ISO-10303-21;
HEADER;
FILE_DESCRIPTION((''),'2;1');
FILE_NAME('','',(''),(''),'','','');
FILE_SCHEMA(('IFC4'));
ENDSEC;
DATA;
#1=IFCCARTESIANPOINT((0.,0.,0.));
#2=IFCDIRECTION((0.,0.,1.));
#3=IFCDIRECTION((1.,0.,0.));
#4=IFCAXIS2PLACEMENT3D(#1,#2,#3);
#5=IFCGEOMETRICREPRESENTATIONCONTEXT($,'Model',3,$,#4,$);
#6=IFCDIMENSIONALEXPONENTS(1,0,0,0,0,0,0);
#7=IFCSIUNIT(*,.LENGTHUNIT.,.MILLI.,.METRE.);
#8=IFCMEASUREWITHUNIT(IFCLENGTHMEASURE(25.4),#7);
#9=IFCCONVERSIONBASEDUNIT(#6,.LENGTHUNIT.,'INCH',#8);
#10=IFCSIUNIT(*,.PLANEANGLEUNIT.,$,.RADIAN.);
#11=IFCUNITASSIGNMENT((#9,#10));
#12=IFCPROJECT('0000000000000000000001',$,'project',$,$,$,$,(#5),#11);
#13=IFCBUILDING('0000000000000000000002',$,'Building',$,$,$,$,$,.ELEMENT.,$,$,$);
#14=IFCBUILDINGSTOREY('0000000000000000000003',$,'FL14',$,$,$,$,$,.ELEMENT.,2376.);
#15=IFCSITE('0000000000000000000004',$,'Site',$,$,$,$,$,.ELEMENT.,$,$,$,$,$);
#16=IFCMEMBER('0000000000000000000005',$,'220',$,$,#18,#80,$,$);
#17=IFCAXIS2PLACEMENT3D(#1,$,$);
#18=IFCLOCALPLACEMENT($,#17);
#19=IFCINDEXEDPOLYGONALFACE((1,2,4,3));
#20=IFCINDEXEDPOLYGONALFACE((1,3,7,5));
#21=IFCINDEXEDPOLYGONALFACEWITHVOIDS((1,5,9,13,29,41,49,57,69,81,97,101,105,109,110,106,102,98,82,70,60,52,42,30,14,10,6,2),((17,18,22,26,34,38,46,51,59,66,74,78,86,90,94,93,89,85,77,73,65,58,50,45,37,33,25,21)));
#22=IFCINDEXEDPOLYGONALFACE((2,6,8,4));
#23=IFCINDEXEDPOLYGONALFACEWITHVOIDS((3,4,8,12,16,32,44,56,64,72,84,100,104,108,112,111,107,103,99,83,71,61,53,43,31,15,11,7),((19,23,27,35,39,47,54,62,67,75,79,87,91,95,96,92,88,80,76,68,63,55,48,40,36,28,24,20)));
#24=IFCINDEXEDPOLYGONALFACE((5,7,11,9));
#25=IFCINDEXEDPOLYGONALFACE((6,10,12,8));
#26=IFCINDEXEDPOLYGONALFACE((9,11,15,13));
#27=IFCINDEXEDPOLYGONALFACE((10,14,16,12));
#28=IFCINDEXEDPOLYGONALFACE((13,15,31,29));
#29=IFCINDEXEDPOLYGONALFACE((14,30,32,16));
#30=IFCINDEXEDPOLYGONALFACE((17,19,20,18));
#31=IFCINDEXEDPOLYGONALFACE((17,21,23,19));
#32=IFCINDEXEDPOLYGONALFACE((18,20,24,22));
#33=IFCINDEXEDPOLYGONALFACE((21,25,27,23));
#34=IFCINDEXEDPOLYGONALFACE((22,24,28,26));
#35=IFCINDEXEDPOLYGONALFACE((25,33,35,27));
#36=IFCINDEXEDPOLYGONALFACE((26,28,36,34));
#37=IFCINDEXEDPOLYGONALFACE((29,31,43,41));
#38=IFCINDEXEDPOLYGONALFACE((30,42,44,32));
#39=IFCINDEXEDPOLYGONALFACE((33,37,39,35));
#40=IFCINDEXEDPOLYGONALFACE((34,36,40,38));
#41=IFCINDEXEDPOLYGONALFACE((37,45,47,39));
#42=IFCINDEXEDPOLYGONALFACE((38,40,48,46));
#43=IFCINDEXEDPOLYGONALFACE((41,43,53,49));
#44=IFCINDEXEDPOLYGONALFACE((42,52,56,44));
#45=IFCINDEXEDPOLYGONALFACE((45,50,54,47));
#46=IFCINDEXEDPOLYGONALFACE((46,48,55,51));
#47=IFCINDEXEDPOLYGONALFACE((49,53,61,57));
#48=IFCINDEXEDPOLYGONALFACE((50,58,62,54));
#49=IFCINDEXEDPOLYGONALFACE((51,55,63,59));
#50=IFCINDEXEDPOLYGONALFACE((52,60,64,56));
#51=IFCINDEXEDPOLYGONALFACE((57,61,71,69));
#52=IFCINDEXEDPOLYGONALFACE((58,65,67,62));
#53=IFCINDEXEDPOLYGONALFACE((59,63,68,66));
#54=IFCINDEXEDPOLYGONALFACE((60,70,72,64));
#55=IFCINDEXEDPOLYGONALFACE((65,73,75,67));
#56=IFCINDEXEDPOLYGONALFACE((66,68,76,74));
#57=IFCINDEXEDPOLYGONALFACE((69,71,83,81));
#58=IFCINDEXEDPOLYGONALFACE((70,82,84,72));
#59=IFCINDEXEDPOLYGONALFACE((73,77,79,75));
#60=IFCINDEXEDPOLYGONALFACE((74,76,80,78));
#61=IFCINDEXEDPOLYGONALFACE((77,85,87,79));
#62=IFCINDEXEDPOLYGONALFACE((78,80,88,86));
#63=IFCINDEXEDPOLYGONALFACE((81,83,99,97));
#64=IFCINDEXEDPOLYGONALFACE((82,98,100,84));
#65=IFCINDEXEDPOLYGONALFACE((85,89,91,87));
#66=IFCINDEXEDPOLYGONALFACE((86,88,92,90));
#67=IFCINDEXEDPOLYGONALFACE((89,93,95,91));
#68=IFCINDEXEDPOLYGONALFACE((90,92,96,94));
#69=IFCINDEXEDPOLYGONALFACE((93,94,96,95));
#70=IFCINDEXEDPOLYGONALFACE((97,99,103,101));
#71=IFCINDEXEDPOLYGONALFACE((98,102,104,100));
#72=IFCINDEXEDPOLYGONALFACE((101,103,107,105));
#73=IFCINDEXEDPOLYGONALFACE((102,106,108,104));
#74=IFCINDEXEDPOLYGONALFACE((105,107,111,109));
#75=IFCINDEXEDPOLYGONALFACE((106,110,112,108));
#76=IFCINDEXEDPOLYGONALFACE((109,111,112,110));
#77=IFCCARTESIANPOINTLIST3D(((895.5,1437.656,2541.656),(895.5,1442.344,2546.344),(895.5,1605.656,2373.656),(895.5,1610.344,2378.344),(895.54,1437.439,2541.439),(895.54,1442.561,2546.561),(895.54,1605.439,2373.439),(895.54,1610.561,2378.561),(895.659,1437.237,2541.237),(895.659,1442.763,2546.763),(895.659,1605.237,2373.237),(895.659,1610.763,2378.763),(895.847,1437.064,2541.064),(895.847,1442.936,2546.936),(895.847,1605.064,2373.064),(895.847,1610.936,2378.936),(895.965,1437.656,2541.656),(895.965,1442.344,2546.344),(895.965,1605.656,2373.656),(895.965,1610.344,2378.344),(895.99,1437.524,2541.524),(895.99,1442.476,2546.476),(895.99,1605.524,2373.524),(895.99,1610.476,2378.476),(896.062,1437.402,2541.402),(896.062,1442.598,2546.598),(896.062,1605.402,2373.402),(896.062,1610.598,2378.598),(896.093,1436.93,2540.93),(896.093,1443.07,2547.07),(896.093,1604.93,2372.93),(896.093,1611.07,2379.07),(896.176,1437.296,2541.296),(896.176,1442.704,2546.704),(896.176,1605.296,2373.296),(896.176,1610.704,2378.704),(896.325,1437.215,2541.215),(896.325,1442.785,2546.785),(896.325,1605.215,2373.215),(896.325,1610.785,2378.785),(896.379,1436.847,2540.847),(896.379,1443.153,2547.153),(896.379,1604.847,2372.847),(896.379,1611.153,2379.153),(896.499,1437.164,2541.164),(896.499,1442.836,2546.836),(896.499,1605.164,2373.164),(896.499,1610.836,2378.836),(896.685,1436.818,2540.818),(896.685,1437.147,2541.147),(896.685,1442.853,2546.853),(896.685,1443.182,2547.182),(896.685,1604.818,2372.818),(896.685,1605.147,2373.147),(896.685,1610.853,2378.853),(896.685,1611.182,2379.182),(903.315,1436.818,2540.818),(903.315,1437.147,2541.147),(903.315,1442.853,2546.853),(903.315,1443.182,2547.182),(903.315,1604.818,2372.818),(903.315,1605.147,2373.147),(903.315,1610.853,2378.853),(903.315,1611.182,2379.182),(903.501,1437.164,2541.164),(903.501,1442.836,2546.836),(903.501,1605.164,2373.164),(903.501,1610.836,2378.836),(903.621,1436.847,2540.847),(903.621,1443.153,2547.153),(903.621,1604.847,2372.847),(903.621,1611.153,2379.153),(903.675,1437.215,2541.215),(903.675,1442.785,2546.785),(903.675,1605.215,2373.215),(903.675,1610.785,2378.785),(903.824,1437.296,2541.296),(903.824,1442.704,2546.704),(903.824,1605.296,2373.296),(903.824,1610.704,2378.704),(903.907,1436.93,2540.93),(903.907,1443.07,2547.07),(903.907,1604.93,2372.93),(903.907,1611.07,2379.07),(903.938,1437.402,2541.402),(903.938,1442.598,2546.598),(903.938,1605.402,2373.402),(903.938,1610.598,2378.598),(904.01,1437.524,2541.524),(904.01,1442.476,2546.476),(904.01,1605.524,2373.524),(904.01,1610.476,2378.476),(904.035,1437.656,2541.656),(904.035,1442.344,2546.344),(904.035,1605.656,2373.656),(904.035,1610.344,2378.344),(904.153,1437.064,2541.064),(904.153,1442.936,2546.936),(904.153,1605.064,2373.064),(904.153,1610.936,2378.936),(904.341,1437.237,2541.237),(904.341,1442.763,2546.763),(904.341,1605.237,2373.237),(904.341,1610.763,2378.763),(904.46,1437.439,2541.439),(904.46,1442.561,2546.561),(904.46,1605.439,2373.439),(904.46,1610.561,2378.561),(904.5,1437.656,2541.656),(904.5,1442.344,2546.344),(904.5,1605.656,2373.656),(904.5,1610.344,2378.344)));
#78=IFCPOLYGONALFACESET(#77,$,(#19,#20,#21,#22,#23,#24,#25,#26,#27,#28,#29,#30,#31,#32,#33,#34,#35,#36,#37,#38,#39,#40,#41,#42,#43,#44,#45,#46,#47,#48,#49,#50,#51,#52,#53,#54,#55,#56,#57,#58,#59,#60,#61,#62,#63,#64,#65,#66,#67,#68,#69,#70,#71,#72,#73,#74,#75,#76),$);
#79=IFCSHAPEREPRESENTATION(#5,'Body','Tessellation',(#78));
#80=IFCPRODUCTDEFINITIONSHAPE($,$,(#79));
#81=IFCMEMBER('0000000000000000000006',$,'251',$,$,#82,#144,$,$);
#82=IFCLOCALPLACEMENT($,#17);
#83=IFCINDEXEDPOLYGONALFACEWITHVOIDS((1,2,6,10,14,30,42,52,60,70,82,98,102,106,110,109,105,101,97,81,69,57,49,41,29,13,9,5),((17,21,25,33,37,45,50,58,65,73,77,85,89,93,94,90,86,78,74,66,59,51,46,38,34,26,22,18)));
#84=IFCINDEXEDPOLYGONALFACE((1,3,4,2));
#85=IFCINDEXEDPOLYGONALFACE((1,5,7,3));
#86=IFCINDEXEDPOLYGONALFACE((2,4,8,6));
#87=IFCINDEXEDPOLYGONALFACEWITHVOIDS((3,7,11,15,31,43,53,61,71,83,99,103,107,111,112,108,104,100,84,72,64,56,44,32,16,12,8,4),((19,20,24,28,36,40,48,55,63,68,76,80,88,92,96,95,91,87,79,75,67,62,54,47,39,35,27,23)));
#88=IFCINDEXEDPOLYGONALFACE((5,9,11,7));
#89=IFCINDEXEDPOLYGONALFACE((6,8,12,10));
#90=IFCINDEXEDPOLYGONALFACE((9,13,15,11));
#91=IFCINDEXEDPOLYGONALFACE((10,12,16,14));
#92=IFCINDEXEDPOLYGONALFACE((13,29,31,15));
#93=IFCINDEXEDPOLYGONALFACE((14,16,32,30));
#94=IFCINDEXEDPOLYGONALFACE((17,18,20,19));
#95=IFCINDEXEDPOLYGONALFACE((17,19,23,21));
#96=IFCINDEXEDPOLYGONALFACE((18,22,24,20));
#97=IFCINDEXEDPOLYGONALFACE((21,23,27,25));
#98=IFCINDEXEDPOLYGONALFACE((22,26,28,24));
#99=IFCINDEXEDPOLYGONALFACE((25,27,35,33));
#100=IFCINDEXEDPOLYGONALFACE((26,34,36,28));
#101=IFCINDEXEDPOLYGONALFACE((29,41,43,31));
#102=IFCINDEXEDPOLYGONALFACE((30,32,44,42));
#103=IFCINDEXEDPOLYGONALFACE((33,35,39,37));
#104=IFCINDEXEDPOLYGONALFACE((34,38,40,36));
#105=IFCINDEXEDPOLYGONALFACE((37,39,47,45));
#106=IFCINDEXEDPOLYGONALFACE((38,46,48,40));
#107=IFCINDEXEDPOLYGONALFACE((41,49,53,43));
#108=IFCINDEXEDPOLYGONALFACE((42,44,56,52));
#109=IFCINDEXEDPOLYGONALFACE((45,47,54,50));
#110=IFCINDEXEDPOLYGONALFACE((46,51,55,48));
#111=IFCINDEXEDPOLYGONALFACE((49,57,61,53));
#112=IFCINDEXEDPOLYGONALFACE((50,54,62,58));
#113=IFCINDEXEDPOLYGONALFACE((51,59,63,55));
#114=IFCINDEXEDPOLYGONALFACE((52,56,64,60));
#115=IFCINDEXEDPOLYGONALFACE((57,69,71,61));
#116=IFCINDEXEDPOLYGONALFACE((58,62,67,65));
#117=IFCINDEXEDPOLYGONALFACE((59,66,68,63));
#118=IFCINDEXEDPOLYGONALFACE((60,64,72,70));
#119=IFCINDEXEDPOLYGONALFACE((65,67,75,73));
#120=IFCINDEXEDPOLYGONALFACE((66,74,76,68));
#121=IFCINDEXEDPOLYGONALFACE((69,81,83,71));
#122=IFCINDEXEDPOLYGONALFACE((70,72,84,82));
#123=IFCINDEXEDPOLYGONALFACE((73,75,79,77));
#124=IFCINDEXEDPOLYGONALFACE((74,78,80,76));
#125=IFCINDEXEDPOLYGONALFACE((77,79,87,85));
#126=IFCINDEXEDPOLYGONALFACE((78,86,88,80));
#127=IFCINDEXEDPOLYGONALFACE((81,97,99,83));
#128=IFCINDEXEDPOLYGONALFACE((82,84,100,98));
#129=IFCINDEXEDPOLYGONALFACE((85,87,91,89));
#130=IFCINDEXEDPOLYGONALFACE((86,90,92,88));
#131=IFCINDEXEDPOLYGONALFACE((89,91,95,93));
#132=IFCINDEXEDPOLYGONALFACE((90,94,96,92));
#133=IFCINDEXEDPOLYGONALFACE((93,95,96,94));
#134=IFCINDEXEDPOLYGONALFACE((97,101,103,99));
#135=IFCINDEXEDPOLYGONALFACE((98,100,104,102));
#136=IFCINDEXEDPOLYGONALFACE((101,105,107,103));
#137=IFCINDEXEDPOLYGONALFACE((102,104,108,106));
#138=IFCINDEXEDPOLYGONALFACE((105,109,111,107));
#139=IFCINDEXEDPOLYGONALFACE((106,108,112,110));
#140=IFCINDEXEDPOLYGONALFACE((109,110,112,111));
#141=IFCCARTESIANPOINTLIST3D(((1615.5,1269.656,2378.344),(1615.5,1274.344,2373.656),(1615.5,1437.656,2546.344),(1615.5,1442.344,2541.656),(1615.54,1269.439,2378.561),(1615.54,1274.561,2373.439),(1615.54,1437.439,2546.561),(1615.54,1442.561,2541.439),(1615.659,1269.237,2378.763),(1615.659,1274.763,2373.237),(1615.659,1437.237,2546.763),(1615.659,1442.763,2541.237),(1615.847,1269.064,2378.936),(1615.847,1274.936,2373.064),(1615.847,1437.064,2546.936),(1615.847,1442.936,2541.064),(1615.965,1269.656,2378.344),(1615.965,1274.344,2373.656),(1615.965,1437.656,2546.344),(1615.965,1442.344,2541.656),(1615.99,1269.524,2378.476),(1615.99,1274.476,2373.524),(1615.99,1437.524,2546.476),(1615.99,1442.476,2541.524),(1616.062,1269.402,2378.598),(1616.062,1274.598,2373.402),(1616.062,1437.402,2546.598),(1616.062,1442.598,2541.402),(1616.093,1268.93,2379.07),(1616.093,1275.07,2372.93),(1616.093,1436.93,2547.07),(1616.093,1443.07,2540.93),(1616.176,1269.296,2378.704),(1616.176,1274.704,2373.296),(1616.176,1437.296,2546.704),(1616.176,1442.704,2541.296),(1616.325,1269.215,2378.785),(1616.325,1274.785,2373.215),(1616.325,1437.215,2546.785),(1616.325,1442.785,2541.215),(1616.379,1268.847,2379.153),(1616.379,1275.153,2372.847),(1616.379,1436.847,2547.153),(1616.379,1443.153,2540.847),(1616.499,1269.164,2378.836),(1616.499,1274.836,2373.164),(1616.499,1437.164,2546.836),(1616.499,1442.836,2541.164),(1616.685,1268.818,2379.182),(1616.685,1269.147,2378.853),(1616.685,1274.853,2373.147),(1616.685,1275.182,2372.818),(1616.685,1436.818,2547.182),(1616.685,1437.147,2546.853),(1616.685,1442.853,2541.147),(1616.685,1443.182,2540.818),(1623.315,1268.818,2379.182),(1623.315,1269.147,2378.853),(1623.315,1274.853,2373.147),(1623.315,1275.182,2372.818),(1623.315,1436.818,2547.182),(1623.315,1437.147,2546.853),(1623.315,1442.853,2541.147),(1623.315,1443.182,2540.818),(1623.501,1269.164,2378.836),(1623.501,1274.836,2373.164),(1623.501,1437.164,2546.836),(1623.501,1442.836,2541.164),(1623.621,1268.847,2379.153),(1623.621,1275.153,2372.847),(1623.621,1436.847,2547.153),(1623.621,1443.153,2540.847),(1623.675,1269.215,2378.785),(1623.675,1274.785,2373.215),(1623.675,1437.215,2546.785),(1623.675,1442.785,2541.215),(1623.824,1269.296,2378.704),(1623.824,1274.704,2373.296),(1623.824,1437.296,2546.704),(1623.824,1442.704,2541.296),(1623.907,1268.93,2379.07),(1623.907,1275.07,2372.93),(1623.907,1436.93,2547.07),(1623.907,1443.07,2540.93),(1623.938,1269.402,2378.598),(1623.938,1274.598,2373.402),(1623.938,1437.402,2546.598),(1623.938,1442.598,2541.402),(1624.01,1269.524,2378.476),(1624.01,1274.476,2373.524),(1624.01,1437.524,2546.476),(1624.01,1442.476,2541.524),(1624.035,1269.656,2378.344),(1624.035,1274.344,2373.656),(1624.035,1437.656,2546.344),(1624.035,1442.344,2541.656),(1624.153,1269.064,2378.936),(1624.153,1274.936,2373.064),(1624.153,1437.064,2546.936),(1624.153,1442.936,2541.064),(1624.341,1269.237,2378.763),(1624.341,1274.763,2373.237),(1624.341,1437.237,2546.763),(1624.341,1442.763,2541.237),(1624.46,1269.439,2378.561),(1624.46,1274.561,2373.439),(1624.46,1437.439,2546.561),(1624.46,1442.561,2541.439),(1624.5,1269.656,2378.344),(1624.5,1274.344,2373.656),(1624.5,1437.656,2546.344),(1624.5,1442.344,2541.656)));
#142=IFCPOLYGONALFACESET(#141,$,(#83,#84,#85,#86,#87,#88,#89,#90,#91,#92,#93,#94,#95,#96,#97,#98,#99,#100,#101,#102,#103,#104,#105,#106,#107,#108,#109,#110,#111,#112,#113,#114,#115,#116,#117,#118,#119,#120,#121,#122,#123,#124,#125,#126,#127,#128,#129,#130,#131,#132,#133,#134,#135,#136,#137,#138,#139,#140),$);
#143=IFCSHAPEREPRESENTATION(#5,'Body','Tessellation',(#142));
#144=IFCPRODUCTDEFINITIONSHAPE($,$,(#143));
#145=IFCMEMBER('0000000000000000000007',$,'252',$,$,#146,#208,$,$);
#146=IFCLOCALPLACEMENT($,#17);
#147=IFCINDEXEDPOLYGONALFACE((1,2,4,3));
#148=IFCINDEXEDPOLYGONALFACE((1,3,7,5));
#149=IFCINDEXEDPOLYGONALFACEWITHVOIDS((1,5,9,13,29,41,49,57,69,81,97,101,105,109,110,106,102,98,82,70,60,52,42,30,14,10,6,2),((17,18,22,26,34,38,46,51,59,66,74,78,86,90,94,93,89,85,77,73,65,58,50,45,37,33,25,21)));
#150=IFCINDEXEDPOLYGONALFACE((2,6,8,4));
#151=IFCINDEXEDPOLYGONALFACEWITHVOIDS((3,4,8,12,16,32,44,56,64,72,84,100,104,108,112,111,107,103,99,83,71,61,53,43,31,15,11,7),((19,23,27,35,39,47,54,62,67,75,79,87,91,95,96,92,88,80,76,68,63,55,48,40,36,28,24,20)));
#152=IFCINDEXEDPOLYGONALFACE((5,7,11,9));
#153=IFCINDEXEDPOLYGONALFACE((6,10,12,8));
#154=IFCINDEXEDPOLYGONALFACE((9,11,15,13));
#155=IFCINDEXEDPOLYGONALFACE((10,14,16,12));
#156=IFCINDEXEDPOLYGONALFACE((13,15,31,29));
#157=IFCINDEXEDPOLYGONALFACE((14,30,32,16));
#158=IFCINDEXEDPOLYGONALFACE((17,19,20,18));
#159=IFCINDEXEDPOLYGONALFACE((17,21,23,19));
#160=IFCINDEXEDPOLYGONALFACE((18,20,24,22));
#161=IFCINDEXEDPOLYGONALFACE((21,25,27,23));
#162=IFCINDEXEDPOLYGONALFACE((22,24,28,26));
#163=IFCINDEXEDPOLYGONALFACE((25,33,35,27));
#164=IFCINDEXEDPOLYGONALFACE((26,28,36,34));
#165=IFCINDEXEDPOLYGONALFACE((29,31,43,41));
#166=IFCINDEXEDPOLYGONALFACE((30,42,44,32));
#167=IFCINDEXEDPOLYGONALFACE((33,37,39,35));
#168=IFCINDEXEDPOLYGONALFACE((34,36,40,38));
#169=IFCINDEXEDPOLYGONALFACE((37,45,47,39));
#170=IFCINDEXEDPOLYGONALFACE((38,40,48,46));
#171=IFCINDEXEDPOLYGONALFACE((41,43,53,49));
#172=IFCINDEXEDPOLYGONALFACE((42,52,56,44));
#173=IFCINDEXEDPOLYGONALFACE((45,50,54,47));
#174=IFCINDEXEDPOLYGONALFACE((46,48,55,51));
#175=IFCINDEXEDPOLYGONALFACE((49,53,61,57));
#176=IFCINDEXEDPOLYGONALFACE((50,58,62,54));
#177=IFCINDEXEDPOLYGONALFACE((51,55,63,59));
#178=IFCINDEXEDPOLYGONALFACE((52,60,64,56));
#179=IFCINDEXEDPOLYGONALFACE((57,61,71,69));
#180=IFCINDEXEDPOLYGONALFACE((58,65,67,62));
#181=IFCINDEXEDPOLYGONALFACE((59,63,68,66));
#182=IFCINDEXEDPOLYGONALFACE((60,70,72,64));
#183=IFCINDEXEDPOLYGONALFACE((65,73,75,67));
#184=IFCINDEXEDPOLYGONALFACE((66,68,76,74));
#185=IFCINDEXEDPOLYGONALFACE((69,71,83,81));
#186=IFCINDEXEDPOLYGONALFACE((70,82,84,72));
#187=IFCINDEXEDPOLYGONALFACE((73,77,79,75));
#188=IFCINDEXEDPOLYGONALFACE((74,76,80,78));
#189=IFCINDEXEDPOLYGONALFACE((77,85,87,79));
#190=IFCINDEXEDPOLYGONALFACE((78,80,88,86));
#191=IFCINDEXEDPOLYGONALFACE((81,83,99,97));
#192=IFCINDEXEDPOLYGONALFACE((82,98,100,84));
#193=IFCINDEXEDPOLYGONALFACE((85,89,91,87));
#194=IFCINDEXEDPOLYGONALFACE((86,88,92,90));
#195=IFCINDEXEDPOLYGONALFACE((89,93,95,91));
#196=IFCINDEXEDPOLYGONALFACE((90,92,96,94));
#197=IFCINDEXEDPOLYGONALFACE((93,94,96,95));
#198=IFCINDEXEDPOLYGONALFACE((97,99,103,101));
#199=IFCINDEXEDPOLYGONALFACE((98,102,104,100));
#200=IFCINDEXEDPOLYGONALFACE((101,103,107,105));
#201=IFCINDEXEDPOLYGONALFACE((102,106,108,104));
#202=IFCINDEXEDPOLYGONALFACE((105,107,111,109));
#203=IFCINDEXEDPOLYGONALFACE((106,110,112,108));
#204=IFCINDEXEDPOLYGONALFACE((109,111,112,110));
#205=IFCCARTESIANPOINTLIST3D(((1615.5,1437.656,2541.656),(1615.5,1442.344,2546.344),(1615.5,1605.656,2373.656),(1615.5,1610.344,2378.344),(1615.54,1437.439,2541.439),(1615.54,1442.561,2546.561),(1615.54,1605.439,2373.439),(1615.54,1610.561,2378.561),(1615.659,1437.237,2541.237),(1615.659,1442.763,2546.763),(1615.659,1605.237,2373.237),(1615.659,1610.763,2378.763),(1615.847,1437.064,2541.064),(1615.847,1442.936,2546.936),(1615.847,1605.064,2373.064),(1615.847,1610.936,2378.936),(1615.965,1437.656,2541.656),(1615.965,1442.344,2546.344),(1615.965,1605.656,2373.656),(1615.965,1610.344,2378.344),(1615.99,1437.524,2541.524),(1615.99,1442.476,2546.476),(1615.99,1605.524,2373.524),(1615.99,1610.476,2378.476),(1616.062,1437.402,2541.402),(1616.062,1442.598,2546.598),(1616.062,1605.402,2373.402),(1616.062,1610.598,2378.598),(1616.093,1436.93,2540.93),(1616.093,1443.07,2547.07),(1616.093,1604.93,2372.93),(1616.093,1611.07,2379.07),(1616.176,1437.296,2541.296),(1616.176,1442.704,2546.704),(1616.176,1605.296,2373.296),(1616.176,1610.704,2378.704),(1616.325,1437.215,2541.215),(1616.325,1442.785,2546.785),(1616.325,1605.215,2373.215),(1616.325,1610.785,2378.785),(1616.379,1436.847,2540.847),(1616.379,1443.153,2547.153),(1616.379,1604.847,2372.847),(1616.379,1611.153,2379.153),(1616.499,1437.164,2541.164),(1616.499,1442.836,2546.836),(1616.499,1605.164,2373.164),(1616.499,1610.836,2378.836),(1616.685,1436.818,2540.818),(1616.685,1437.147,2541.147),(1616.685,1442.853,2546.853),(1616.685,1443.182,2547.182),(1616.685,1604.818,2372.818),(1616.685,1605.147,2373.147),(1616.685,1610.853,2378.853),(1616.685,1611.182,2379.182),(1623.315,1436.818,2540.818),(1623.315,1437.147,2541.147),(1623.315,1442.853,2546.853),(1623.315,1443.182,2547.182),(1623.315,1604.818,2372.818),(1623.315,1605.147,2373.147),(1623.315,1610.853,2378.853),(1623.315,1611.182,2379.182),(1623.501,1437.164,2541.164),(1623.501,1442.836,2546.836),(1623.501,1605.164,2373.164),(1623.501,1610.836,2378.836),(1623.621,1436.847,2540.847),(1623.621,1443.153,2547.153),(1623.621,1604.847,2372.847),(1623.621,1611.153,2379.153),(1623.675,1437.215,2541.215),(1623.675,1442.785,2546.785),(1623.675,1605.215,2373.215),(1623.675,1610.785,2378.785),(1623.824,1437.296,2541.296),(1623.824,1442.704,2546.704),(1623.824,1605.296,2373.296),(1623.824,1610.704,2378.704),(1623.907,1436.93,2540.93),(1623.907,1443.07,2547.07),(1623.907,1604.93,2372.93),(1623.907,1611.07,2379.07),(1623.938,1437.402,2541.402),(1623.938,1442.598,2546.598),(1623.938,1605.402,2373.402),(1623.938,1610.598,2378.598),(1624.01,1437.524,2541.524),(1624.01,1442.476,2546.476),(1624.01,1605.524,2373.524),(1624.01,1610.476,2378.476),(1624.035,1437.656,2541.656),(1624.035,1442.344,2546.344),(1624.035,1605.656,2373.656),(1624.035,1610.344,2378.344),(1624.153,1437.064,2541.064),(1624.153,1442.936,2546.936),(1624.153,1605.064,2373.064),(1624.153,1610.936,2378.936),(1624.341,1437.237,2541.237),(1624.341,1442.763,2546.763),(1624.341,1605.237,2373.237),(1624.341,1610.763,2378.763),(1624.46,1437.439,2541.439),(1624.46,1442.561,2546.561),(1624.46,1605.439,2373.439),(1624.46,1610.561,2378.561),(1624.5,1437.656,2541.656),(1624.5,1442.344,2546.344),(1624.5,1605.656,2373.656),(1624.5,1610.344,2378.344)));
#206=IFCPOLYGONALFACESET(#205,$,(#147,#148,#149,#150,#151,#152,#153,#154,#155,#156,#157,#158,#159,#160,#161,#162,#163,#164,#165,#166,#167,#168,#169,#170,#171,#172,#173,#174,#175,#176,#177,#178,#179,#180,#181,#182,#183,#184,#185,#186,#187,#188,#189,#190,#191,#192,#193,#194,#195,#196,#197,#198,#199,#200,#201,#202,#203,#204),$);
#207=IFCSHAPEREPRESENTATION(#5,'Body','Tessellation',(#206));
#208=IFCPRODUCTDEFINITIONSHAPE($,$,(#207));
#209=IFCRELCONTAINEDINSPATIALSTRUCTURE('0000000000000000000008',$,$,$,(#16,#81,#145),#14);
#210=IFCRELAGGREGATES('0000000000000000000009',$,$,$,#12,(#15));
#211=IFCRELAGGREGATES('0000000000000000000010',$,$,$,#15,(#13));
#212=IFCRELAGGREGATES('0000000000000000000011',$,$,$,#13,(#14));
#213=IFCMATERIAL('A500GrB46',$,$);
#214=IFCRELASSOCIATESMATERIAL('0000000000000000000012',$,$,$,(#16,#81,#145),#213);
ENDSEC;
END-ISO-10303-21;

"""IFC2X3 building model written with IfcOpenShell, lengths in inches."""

from ifc_helpers import new_model, entity, si_unit, converted_unit, frame, origin_with_axes, origin_2d_with_axis, place, context, project, spatial, hollow_rectangle, extrude, material, element, save


model = new_model("IFC2X3")

# Units and contexts
model_context = context("Model", 3, world=origin_with_axes())
ifc_project = project(units=[converted_unit("LENGTHUNIT", "INCH", entity("IfcLengthMeasure", 25.4), si_unit("LENGTHUNIT", "METRE", prefix="MILLI"), dimensions=[1, 0, 0, 0, 0, 0, 0]), si_unit("PLANEANGLEUNIT", "RADIAN")], contexts=[model_context])

# Site, building, storey
site = spatial("IfcSite", under=ifc_project, Name="Site", CompositionType="ELEMENT")
building = spatial("IfcBuilding", under=site, Name="Building", CompositionType="ELEMENT")
storey = spatial("IfcBuildingStorey", under=building, Name="FL14", CompositionType="ELEMENT", Elevation=2376.0)

# Members
ifc_material_1 = material(Name="A500GrB46")
for number, where, z_axis, x_axis, name in (
    (1, (900.0, 1608.0, 2376.0), (0.0, -0.707107, 0.707107), (1.0, 0.0, 0.0), "220"),
    (2, (1620.0, 1272.0, 2376.0), (0.0, 0.707107, 0.707107), (-1.0, 0.0, 0.0), "251"),
    (3, (1620.0, 1608.0, 2376.0), (0.0, -0.707107, 0.707107), (1.0, 0.0, 0.0), "252"),
):
    element("IfcMember", number, at=place(None, frame(where, z_axis=z_axis, x_axis=x_axis)), inside=storey, material=ifc_material_1, Name=name, context=model_context, shape_type="SweptSolid", body=[
        extrude(hollow_rectangle(XDim=9.0, YDim=9.0, WallThickness=0.465, InnerFilletRadius=0.72, OuterFilletRadius=1.185, at=origin_2d_with_axis()), origin_with_axes(), (0.0, 0.0, 1.0), 237.588),
    ])

save(model, "model.ifc")
